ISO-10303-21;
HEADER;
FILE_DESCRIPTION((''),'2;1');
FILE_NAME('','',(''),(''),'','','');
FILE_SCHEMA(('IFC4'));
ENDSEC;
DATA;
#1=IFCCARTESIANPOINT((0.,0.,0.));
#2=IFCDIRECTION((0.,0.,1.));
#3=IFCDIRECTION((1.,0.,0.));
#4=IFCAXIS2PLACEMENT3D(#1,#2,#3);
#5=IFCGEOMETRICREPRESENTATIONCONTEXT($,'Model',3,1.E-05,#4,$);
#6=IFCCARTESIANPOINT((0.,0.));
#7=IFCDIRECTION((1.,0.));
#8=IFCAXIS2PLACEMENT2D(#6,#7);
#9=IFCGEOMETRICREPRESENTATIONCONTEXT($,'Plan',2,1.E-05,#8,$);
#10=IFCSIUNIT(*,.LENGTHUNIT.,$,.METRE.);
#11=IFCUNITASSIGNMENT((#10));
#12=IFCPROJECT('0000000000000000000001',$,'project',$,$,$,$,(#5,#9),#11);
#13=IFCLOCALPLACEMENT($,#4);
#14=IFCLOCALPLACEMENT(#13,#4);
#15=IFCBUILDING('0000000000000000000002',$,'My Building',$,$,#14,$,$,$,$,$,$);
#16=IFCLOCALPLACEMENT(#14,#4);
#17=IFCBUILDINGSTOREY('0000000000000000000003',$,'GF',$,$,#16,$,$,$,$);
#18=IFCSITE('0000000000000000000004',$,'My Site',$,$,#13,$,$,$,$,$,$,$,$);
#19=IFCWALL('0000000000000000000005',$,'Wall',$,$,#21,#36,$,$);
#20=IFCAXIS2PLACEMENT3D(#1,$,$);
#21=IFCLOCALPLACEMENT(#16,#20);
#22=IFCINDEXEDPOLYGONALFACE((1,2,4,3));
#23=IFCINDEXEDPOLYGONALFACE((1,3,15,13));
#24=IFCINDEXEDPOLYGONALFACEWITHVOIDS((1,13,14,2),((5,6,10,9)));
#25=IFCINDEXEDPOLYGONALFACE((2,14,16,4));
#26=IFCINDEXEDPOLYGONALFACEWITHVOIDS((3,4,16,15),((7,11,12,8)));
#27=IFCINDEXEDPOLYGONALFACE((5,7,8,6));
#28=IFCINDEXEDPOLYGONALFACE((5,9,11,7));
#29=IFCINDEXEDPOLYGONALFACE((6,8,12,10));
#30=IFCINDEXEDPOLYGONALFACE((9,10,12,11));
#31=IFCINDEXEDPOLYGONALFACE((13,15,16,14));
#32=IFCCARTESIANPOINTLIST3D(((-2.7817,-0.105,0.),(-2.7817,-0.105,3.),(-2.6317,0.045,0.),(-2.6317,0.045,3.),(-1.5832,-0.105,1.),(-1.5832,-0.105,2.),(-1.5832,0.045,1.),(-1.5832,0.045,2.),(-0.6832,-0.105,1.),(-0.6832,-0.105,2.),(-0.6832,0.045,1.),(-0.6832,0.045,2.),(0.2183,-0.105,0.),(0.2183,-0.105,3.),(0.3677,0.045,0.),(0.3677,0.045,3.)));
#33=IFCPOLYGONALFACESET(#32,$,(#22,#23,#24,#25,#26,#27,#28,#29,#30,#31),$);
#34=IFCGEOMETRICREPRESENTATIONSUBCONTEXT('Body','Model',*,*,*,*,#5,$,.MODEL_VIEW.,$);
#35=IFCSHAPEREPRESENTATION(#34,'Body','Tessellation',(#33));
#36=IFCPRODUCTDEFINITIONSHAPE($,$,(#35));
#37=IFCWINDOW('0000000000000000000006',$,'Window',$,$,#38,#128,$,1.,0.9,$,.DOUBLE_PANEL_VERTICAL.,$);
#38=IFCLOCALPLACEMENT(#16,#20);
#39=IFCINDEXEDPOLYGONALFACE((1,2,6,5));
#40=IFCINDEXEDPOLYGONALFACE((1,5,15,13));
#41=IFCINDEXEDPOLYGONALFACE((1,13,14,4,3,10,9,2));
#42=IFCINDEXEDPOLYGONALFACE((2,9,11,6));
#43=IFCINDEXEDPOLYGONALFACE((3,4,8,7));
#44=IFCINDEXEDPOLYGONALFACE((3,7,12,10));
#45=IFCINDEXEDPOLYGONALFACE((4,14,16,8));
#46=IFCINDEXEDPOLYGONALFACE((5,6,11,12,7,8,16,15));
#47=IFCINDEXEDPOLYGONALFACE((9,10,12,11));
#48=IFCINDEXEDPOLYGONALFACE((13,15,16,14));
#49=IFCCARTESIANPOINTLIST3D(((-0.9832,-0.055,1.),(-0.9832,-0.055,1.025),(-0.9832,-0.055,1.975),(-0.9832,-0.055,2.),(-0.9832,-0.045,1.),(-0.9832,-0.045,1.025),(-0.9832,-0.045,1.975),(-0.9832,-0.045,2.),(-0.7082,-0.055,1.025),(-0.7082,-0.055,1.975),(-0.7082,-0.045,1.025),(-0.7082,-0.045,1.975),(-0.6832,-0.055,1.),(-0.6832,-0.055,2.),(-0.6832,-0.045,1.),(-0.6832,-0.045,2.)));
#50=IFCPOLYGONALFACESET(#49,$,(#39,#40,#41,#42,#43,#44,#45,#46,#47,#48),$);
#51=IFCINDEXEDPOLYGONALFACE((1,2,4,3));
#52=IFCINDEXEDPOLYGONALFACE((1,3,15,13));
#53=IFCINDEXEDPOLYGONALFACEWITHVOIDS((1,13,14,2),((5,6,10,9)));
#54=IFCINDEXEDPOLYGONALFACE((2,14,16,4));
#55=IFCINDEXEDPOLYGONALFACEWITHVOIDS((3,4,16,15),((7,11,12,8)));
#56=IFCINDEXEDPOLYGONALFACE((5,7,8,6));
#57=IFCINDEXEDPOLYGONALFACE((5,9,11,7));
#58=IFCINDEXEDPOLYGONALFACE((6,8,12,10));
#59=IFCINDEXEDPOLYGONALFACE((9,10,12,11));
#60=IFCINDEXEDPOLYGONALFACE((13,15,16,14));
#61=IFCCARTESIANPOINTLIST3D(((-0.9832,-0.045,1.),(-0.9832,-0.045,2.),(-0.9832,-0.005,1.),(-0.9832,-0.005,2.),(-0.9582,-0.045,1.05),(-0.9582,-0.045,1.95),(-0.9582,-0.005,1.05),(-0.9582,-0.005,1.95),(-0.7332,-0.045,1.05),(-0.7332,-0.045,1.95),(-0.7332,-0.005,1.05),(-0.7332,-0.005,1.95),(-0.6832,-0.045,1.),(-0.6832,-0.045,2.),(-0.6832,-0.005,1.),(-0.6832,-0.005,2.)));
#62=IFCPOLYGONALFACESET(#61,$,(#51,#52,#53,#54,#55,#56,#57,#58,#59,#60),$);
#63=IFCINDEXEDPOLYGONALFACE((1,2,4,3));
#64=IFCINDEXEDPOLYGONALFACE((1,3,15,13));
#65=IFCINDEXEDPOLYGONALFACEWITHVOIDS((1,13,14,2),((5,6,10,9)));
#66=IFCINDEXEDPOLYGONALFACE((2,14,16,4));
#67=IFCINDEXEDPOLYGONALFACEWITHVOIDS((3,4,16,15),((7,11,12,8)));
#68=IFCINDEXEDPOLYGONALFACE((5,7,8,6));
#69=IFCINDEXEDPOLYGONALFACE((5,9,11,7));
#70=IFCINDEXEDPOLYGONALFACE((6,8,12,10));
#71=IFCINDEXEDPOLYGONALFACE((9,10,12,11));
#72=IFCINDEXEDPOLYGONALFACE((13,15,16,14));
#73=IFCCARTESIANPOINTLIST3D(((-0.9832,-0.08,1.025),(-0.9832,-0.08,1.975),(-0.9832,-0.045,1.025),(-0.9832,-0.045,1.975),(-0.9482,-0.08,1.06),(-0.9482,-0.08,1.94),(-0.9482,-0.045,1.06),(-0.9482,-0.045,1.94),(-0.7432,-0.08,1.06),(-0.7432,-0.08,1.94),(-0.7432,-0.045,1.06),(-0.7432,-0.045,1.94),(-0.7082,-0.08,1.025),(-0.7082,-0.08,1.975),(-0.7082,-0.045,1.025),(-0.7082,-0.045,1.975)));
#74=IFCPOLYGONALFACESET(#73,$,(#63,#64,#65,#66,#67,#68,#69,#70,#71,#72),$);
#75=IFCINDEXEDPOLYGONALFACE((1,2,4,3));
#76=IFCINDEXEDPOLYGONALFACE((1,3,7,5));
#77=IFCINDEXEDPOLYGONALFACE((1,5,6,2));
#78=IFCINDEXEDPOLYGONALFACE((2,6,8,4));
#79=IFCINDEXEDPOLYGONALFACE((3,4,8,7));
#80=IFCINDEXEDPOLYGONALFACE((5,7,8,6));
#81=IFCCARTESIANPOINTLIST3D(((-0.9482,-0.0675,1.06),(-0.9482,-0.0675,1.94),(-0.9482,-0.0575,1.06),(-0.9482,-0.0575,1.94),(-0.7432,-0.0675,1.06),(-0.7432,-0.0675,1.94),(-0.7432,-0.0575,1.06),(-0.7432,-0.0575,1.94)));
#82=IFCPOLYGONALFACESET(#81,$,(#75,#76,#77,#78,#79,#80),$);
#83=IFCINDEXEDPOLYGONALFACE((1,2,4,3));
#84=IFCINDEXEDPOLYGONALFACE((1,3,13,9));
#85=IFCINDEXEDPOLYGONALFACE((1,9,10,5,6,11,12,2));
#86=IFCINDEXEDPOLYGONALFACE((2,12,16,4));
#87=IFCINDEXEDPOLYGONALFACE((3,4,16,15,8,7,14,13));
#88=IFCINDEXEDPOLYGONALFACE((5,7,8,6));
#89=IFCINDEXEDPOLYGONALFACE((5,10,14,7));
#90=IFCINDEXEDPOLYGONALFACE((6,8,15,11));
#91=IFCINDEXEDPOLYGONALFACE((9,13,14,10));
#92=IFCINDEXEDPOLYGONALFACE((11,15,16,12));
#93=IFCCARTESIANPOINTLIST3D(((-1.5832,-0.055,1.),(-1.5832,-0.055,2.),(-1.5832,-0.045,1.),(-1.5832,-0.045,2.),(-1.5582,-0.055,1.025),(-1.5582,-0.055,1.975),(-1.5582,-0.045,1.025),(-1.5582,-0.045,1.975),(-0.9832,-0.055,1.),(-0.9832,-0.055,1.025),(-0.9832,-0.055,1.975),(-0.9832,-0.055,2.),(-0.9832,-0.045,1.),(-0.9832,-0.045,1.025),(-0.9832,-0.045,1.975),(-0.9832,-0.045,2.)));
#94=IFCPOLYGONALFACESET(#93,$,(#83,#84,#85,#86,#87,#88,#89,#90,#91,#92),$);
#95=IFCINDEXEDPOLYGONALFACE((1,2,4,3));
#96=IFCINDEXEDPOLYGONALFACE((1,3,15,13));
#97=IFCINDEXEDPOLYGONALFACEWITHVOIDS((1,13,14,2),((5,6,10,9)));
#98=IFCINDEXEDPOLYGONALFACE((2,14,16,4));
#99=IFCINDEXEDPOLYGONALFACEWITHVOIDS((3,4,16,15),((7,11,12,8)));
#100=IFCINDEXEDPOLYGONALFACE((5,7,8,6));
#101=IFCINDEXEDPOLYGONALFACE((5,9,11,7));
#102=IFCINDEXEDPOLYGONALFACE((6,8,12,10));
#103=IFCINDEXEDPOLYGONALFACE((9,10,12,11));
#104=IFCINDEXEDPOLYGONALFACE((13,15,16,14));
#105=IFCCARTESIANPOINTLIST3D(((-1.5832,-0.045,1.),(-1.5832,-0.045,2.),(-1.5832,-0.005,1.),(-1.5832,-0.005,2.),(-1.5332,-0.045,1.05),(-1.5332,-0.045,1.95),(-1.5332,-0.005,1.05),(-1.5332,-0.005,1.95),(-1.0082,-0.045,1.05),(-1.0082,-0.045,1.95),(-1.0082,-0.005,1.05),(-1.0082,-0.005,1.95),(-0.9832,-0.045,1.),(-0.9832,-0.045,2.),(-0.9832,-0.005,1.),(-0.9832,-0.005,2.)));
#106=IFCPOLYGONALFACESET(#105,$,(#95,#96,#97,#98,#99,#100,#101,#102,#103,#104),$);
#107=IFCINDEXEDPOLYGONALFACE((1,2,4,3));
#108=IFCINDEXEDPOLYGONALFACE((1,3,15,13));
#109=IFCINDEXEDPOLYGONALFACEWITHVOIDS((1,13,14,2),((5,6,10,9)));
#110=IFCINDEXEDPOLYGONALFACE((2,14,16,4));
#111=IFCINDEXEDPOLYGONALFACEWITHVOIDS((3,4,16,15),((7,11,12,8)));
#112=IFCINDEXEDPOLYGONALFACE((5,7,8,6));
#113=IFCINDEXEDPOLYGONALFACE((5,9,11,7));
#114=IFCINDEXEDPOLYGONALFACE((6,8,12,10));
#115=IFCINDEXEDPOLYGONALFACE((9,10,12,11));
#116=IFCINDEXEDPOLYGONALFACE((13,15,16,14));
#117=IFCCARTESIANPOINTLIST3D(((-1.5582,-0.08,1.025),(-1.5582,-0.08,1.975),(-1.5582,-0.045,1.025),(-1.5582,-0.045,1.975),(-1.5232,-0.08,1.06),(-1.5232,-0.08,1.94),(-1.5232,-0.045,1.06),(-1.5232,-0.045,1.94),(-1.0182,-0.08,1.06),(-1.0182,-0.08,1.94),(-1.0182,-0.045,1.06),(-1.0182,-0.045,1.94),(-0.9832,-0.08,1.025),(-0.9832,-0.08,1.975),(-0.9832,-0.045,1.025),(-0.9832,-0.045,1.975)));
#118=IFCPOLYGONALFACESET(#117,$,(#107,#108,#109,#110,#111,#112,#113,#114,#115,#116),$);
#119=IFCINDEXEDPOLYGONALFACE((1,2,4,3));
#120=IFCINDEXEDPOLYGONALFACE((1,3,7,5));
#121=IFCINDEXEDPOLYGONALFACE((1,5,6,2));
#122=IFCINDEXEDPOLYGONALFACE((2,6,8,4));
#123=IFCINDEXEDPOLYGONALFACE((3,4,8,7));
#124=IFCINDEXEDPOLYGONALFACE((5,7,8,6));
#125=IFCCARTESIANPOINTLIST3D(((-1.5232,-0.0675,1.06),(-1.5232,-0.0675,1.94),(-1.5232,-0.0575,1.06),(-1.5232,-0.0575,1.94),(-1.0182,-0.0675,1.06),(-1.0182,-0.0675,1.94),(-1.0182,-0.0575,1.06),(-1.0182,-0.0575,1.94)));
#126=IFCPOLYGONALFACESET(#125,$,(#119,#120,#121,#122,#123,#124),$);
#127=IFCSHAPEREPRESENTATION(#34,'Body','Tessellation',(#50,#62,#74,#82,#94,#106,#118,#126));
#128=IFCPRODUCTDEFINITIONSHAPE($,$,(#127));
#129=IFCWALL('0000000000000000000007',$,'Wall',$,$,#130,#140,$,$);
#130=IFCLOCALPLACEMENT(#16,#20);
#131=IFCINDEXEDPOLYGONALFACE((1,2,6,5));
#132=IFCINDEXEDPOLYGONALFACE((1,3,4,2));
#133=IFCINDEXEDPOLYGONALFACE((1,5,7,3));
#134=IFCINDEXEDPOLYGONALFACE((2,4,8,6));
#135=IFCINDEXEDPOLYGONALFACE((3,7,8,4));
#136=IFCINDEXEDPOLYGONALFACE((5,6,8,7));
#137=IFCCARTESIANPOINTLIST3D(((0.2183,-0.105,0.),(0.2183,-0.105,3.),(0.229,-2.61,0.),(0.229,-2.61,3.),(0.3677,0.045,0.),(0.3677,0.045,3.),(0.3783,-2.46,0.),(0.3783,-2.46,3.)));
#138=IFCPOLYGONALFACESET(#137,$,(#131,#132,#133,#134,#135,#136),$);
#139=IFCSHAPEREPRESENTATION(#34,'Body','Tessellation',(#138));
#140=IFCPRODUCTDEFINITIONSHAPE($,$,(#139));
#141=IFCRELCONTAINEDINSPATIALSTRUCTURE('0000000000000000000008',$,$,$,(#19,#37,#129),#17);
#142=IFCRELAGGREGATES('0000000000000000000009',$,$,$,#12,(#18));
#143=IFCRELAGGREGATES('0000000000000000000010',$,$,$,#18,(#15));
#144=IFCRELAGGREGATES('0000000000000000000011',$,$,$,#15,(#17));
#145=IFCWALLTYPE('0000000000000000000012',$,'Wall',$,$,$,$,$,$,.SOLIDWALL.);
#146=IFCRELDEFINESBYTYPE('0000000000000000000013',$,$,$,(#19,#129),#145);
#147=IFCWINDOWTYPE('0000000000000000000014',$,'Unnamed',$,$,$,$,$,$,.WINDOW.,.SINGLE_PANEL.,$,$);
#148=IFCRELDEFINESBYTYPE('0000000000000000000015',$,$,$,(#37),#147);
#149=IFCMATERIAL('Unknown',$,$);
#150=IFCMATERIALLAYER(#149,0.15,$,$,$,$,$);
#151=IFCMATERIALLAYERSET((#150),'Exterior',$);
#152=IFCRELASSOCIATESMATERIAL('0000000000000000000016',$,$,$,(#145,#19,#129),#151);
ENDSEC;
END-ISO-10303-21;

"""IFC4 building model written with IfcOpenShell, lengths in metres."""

from ifc_helpers import new_model, entity, si_unit, frame, origin_with_axes, origin_2d_with_axis, place, context, subcontext, project, spatial, line, indexed_curve, outline, extrude, shape, source, transform, mapped, material, layer, layer_set, layer_usage, type_object, type_shapes, element, fill, save


model = new_model("IFC4")

# Units and contexts
model_context = context("Model", 3, precision=1e-05, world=origin_with_axes())
plan_context = context("Plan", 2, precision=1e-05, world=origin_2d_with_axis())
body_context_1 = subcontext(model_context, "Body", "Model", "MODEL_VIEW")
body_context_2 = subcontext(plan_context, "Body", "Plan", "PLAN_VIEW")
ifc_project = project(units=[si_unit("LENGTHUNIT", "METRE")], contexts=[model_context, plan_context])

# Site, building, storey
site_placement = place(None, origin_with_axes())
site = spatial("IfcSite", under=ifc_project, at=site_placement, Name="My Site")
building_placement = place(site_placement, origin_with_axes())
building = spatial("IfcBuilding", under=site, at=building_placement, Name="My Building")
storey_placement = place(building_placement, origin_with_axes())
storey = spatial("IfcBuildingStorey", under=building, at=storey_placement, Name="GF")

# Shared definitions
ifc_material = material(Name="Unknown")

# Shared definitions
ifc_layer_1 = layer(ifc_material, 0.15)
ifc_layer_set_1 = layer_set([ifc_layer_1], Name="Exterior")
wall_type_1 = type_object("IfcWallType", Name="Wall", PredefinedType="SOLIDWALL", material=ifc_layer_set_1)

# Wall, opening, window
ifc_layer_usage_1 = layer_usage(ifc_layer_set_1, "AXIS2", "POSITIVE", 0.0)
wall_1_placement = place(storey_placement, frame((-2.7817, -0.105, 0.0), z_axis=(0.0, 0.0, 1.0), x_axis=(1.0, 0.0, 0.0)))
wall_1 = element("IfcWall", 1, at=wall_1_placement, inside=storey, type_object=wall_type_1, material=ifc_layer_usage_1, Name="Wall", context=body_context_1, shape_type="SweptSolid", body=[
    extrude(outline(indexed_curve([(0.0, 0.0), (0.15, 0.15), (3.1494, 0.15), (3.0, 0.0)], segments=[line(1, 2, 3, 4, 1)])), origin_with_axes(), (0.0, 0.0, 1.0), 3.0),
])
shared_shape_1 = source(origin_with_axes(), body_context_1, "Body", "SweptSolid", [
    extrude(outline(indexed_curve([(0.0, 0.0), (0.9, 0.0), (0.9, 1.0), (0.0, 1.0)], segments=[line(1, 2, 3, 4, 1)])), frame((0.0, -0.6, 0.0), z_axis=(0.0, -1.0, 0.0), x_axis=(1.0, 0.0, 0.0)), (0.0, 0.0, -1.0), 1.2),
])
opening_1_placement = place(wall_1_placement, frame((2.0985, 0.15, 1.0), z_axis=(0.0, 0.0, 1.0), x_axis=(-1.0, 0.0, 0.0)))
opening_1 = element("IfcOpeningElement", 2, at=opening_1_placement, cuts=wall_1, PredefinedType="OPENING", context=body_context_1, shape_type="MappedRepresentation", body=[
    mapped(shared_shape_1, transform((0.0, 0.0, 0.0), x_axis=(1.0, 0.0, 0.0), y_axis=(0.0, 1.0, 0.0), z_axis=(0.0, 0.0, 1.0), scale=1.0)),
])
window_type = type_object("IfcWindowType", Name="Unnamed", PartitioningType="SINGLE_PANEL", PredefinedType="WINDOW")
shared_shape_2 = source(origin_with_axes(), body_context_1, "Body", "SweptSolid", [
    extrude(outline(indexed_curve([(0.3, 0.0), (0.0, 0.0), (0.0, 1.0), (0.3, 1.0), (0.3, 0.975), (0.025, 0.975), (0.025, 0.025), (0.3, 0.025)], segments=[line(1, 2, 3, 4, 5, 6, 7, 8, 1)])), frame((0.0, 0.09, 0.0), z_axis=(0.0, -1.0, 0.0), x_axis=(1.0, 0.0, 0.0)), (0.0, 0.0, -1.0), 0.01),
    extrude(outline(indexed_curve([(0.0, 0.0), (0.3, 0.0), (0.3, 1.0), (0.0, 1.0)], segments=[line(1, 2, 3, 4, 1)]), holes=[indexed_curve([(0.05, 0.05), (0.275, 0.05), (0.275, 0.95), (0.05, 0.95)], segments=[line(1, 2, 3, 4, 1)])]), frame((0.0, 0.05, 0.0), z_axis=(0.0, -1.0, 0.0), x_axis=(1.0, 0.0, 0.0)), (0.0, 0.0, -1.0), 0.04),
    extrude(outline(indexed_curve([(0.0, 0.0), (0.275, 0.0), (0.275, 0.95), (0.0, 0.95)], segments=[line(1, 2, 3, 4, 1)]), holes=[indexed_curve([(0.035, 0.035), (0.24, 0.035), (0.24, 0.915), (0.035, 0.915)], segments=[line(1, 2, 3, 4, 1)])]), frame((0.025, 0.09, 0.025), z_axis=(0.0, -1.0, 0.0), x_axis=(1.0, 0.0, 0.0)), (0.0, 0.0, -1.0), 0.035),
    extrude(outline(indexed_curve([(0.035, 0.035), (0.24, 0.035), (0.24, 0.915), (0.035, 0.915)], segments=[line(1, 2, 3, 4, 1)])), frame((0.025, 0.1025, 0.025), z_axis=(0.0, -1.0, 0.0), x_axis=(1.0, 0.0, 0.0)), (0.0, 0.0, -1.0), 0.01),
    extrude(outline(indexed_curve([(0.0, 1.0), (0.6, 1.0), (0.6, 0.0), (0.0, 0.0), (0.0, 0.025), (0.575, 0.025), (0.575, 0.975), (0.0, 0.975)], segments=[line(1, 2, 3, 4, 5, 6, 7, 8, 1)])), frame((0.3, 0.09, 0.0), z_axis=(0.0, -1.0, 0.0), x_axis=(1.0, 0.0, 0.0)), (0.0, 0.0, -1.0), 0.01),
    extrude(outline(indexed_curve([(0.0, 0.0), (0.6, 0.0), (0.6, 1.0), (0.0, 1.0)], segments=[line(1, 2, 3, 4, 1)]), holes=[indexed_curve([(0.025, 0.05), (0.55, 0.05), (0.55, 0.95), (0.025, 0.95)], segments=[line(1, 2, 3, 4, 1)])]), frame((0.3, 0.05, 0.0), z_axis=(0.0, -1.0, 0.0), x_axis=(1.0, 0.0, 0.0)), (0.0, 0.0, -1.0), 0.04),
    extrude(outline(indexed_curve([(0.0, 0.0), (0.575, 0.0), (0.575, 0.95), (0.0, 0.95)], segments=[line(1, 2, 3, 4, 1)]), holes=[indexed_curve([(0.035, 0.035), (0.54, 0.035), (0.54, 0.915), (0.035, 0.915)], segments=[line(1, 2, 3, 4, 1)])]), frame((0.3, 0.09, 0.025), z_axis=(0.0, -1.0, 0.0), x_axis=(1.0, 0.0, 0.0)), (0.0, 0.0, -1.0), 0.035),
    extrude(outline(indexed_curve([(0.035, 0.035), (0.54, 0.035), (0.54, 0.915), (0.035, 0.915)], segments=[line(1, 2, 3, 4, 1)])), frame((0.3, 0.1025, 0.025), z_axis=(0.0, -1.0, 0.0), x_axis=(1.0, 0.0, 0.0)), (0.0, 0.0, -1.0), 0.01),
])
shared_shape_3 = source(origin_with_axes(), body_context_2, "Body", "Curve2D", [
    entity("IfcIndexedPolyCurve", entity("IfcCartesianPointList2D", [[0.05, 0.05], [0.275, 0.05]])),
    entity("IfcIndexedPolyCurve", entity("IfcCartesianPointList2D", [[0.0, 0.1], [0.025, 0.1], [0.025, 0.09], [0.05, 0.09], [0.05, 0.05], [0.0, 0.05]]), [entity("IfcLineIndex", [1, 2, 3, 4, 5, 6, 1])]),
    entity("IfcIndexedPolyCurve", entity("IfcCartesianPointList2D", [[0.3, 0.1], [0.3, 0.1], [0.3, 0.09], [0.275, 0.09], [0.275, 0.05], [0.3, 0.05]])),
    entity("IfcIndexedPolyCurve", entity("IfcCartesianPointList2D", [[0.025, 0.09], [0.06, 0.09], [0.06, 0.125], [0.025, 0.125]]), [entity("IfcLineIndex", [1, 2, 3, 4, 1])]),
    entity("IfcIndexedPolyCurve", entity("IfcCartesianPointList2D", [[0.3, 0.09], [0.265, 0.09], [0.265, 0.125], [0.3, 0.125]]), [entity("IfcLineIndex", [1, 2, 3, 4, 1])]),
    entity("IfcIndexedPolyCurve", entity("IfcCartesianPointList2D", [[0.06, 0.09], [0.265, 0.09]])),
    entity("IfcIndexedPolyCurve", entity("IfcCartesianPointList2D", [[0.06, 0.125], [0.265, 0.125]])),
    entity("IfcIndexedPolyCurve", entity("IfcCartesianPointList2D", [[0.06, 0.1075], [0.265, 0.1075]])),
    entity("IfcIndexedPolyCurve", entity("IfcCartesianPointList2D", [[0.325, 0.05], [0.85, 0.05]])),
    entity("IfcIndexedPolyCurve", entity("IfcCartesianPointList2D", [[0.3, 0.1], [0.3, 0.1], [0.3, 0.09], [0.325, 0.09], [0.325, 0.05], [0.3, 0.05]])),
    entity("IfcIndexedPolyCurve", entity("IfcCartesianPointList2D", [[0.9, 0.1], [0.875, 0.1], [0.875, 0.09], [0.85, 0.09], [0.85, 0.05], [0.9, 0.05]]), [entity("IfcLineIndex", [1, 2, 3, 4, 5, 6, 1])]),
    entity("IfcIndexedPolyCurve", entity("IfcCartesianPointList2D", [[0.3, 0.09], [0.335, 0.09], [0.335, 0.125], [0.3, 0.125]]), [entity("IfcLineIndex", [1, 2, 3, 4, 1])]),
    entity("IfcIndexedPolyCurve", entity("IfcCartesianPointList2D", [[0.875, 0.09], [0.84, 0.09], [0.84, 0.125], [0.875, 0.125]]), [entity("IfcLineIndex", [1, 2, 3, 4, 1])]),
    entity("IfcIndexedPolyCurve", entity("IfcCartesianPointList2D", [[0.335, 0.09], [0.84, 0.09]])),
    entity("IfcIndexedPolyCurve", entity("IfcCartesianPointList2D", [[0.335, 0.125], [0.84, 0.125]])),
    entity("IfcIndexedPolyCurve", entity("IfcCartesianPointList2D", [[0.335, 0.1075], [0.84, 0.1075]])),
])
type_shapes(window_type, [shared_shape_2, shared_shape_3])
window_placement = place(opening_1_placement, origin_with_axes())
window = element("IfcWindow", 3, at=window_placement, inside=storey, type_object=window_type, Name="Window", OverallHeight=1.0, OverallWidth=0.9, PartitioningType="DOUBLE_PANEL_VERTICAL", shapes=[
    shape(body_context_1, "Body", "MappedRepresentation", [mapped(shared_shape_2, transform((0.0, 0.0, 0.0), x_axis=(1.0, 0.0, 0.0), y_axis=(0.0, 1.0, 0.0), z_axis=(0.0, 0.0, 1.0), scale=1.0))]),
    shape(body_context_2, "Body", "MappedRepresentation", [mapped(shared_shape_3, transform((0.0, 0.0, 0.0), x_axis=(1.0, 0.0, 0.0), y_axis=(0.0, 1.0, 0.0), z_axis=(0.0, 0.0, 1.0), scale=1.0))]),
])
fill(opening_1, window)

# Wall
ifc_layer_usage_2 = layer_usage(ifc_layer_set_1, "AXIS2", "POSITIVE", 0.0)
wall_2_placement = place(storey_placement, frame((0.2183, -0.105, 0.0), z_axis=(0.0, 0.0, 1.0), x_axis=(0.004245, -0.999991, 0.0)))
element("IfcWall", 4, at=wall_2_placement, inside=storey, type_object=wall_type_1, material=ifc_layer_usage_2, Name="Wall", context=body_context_1, shape_type="SweptSolid", body=[
    extrude(outline(indexed_curve([(0.0, 0.0), (-0.1494, 0.15), (2.3557, 0.15), (2.505, 0.0)], segments=[line(1, 2, 3, 4, 1)])), origin_with_axes(), (0.0, 0.0, 1.0), 3.0),
])

save(model, "model.ifc")
